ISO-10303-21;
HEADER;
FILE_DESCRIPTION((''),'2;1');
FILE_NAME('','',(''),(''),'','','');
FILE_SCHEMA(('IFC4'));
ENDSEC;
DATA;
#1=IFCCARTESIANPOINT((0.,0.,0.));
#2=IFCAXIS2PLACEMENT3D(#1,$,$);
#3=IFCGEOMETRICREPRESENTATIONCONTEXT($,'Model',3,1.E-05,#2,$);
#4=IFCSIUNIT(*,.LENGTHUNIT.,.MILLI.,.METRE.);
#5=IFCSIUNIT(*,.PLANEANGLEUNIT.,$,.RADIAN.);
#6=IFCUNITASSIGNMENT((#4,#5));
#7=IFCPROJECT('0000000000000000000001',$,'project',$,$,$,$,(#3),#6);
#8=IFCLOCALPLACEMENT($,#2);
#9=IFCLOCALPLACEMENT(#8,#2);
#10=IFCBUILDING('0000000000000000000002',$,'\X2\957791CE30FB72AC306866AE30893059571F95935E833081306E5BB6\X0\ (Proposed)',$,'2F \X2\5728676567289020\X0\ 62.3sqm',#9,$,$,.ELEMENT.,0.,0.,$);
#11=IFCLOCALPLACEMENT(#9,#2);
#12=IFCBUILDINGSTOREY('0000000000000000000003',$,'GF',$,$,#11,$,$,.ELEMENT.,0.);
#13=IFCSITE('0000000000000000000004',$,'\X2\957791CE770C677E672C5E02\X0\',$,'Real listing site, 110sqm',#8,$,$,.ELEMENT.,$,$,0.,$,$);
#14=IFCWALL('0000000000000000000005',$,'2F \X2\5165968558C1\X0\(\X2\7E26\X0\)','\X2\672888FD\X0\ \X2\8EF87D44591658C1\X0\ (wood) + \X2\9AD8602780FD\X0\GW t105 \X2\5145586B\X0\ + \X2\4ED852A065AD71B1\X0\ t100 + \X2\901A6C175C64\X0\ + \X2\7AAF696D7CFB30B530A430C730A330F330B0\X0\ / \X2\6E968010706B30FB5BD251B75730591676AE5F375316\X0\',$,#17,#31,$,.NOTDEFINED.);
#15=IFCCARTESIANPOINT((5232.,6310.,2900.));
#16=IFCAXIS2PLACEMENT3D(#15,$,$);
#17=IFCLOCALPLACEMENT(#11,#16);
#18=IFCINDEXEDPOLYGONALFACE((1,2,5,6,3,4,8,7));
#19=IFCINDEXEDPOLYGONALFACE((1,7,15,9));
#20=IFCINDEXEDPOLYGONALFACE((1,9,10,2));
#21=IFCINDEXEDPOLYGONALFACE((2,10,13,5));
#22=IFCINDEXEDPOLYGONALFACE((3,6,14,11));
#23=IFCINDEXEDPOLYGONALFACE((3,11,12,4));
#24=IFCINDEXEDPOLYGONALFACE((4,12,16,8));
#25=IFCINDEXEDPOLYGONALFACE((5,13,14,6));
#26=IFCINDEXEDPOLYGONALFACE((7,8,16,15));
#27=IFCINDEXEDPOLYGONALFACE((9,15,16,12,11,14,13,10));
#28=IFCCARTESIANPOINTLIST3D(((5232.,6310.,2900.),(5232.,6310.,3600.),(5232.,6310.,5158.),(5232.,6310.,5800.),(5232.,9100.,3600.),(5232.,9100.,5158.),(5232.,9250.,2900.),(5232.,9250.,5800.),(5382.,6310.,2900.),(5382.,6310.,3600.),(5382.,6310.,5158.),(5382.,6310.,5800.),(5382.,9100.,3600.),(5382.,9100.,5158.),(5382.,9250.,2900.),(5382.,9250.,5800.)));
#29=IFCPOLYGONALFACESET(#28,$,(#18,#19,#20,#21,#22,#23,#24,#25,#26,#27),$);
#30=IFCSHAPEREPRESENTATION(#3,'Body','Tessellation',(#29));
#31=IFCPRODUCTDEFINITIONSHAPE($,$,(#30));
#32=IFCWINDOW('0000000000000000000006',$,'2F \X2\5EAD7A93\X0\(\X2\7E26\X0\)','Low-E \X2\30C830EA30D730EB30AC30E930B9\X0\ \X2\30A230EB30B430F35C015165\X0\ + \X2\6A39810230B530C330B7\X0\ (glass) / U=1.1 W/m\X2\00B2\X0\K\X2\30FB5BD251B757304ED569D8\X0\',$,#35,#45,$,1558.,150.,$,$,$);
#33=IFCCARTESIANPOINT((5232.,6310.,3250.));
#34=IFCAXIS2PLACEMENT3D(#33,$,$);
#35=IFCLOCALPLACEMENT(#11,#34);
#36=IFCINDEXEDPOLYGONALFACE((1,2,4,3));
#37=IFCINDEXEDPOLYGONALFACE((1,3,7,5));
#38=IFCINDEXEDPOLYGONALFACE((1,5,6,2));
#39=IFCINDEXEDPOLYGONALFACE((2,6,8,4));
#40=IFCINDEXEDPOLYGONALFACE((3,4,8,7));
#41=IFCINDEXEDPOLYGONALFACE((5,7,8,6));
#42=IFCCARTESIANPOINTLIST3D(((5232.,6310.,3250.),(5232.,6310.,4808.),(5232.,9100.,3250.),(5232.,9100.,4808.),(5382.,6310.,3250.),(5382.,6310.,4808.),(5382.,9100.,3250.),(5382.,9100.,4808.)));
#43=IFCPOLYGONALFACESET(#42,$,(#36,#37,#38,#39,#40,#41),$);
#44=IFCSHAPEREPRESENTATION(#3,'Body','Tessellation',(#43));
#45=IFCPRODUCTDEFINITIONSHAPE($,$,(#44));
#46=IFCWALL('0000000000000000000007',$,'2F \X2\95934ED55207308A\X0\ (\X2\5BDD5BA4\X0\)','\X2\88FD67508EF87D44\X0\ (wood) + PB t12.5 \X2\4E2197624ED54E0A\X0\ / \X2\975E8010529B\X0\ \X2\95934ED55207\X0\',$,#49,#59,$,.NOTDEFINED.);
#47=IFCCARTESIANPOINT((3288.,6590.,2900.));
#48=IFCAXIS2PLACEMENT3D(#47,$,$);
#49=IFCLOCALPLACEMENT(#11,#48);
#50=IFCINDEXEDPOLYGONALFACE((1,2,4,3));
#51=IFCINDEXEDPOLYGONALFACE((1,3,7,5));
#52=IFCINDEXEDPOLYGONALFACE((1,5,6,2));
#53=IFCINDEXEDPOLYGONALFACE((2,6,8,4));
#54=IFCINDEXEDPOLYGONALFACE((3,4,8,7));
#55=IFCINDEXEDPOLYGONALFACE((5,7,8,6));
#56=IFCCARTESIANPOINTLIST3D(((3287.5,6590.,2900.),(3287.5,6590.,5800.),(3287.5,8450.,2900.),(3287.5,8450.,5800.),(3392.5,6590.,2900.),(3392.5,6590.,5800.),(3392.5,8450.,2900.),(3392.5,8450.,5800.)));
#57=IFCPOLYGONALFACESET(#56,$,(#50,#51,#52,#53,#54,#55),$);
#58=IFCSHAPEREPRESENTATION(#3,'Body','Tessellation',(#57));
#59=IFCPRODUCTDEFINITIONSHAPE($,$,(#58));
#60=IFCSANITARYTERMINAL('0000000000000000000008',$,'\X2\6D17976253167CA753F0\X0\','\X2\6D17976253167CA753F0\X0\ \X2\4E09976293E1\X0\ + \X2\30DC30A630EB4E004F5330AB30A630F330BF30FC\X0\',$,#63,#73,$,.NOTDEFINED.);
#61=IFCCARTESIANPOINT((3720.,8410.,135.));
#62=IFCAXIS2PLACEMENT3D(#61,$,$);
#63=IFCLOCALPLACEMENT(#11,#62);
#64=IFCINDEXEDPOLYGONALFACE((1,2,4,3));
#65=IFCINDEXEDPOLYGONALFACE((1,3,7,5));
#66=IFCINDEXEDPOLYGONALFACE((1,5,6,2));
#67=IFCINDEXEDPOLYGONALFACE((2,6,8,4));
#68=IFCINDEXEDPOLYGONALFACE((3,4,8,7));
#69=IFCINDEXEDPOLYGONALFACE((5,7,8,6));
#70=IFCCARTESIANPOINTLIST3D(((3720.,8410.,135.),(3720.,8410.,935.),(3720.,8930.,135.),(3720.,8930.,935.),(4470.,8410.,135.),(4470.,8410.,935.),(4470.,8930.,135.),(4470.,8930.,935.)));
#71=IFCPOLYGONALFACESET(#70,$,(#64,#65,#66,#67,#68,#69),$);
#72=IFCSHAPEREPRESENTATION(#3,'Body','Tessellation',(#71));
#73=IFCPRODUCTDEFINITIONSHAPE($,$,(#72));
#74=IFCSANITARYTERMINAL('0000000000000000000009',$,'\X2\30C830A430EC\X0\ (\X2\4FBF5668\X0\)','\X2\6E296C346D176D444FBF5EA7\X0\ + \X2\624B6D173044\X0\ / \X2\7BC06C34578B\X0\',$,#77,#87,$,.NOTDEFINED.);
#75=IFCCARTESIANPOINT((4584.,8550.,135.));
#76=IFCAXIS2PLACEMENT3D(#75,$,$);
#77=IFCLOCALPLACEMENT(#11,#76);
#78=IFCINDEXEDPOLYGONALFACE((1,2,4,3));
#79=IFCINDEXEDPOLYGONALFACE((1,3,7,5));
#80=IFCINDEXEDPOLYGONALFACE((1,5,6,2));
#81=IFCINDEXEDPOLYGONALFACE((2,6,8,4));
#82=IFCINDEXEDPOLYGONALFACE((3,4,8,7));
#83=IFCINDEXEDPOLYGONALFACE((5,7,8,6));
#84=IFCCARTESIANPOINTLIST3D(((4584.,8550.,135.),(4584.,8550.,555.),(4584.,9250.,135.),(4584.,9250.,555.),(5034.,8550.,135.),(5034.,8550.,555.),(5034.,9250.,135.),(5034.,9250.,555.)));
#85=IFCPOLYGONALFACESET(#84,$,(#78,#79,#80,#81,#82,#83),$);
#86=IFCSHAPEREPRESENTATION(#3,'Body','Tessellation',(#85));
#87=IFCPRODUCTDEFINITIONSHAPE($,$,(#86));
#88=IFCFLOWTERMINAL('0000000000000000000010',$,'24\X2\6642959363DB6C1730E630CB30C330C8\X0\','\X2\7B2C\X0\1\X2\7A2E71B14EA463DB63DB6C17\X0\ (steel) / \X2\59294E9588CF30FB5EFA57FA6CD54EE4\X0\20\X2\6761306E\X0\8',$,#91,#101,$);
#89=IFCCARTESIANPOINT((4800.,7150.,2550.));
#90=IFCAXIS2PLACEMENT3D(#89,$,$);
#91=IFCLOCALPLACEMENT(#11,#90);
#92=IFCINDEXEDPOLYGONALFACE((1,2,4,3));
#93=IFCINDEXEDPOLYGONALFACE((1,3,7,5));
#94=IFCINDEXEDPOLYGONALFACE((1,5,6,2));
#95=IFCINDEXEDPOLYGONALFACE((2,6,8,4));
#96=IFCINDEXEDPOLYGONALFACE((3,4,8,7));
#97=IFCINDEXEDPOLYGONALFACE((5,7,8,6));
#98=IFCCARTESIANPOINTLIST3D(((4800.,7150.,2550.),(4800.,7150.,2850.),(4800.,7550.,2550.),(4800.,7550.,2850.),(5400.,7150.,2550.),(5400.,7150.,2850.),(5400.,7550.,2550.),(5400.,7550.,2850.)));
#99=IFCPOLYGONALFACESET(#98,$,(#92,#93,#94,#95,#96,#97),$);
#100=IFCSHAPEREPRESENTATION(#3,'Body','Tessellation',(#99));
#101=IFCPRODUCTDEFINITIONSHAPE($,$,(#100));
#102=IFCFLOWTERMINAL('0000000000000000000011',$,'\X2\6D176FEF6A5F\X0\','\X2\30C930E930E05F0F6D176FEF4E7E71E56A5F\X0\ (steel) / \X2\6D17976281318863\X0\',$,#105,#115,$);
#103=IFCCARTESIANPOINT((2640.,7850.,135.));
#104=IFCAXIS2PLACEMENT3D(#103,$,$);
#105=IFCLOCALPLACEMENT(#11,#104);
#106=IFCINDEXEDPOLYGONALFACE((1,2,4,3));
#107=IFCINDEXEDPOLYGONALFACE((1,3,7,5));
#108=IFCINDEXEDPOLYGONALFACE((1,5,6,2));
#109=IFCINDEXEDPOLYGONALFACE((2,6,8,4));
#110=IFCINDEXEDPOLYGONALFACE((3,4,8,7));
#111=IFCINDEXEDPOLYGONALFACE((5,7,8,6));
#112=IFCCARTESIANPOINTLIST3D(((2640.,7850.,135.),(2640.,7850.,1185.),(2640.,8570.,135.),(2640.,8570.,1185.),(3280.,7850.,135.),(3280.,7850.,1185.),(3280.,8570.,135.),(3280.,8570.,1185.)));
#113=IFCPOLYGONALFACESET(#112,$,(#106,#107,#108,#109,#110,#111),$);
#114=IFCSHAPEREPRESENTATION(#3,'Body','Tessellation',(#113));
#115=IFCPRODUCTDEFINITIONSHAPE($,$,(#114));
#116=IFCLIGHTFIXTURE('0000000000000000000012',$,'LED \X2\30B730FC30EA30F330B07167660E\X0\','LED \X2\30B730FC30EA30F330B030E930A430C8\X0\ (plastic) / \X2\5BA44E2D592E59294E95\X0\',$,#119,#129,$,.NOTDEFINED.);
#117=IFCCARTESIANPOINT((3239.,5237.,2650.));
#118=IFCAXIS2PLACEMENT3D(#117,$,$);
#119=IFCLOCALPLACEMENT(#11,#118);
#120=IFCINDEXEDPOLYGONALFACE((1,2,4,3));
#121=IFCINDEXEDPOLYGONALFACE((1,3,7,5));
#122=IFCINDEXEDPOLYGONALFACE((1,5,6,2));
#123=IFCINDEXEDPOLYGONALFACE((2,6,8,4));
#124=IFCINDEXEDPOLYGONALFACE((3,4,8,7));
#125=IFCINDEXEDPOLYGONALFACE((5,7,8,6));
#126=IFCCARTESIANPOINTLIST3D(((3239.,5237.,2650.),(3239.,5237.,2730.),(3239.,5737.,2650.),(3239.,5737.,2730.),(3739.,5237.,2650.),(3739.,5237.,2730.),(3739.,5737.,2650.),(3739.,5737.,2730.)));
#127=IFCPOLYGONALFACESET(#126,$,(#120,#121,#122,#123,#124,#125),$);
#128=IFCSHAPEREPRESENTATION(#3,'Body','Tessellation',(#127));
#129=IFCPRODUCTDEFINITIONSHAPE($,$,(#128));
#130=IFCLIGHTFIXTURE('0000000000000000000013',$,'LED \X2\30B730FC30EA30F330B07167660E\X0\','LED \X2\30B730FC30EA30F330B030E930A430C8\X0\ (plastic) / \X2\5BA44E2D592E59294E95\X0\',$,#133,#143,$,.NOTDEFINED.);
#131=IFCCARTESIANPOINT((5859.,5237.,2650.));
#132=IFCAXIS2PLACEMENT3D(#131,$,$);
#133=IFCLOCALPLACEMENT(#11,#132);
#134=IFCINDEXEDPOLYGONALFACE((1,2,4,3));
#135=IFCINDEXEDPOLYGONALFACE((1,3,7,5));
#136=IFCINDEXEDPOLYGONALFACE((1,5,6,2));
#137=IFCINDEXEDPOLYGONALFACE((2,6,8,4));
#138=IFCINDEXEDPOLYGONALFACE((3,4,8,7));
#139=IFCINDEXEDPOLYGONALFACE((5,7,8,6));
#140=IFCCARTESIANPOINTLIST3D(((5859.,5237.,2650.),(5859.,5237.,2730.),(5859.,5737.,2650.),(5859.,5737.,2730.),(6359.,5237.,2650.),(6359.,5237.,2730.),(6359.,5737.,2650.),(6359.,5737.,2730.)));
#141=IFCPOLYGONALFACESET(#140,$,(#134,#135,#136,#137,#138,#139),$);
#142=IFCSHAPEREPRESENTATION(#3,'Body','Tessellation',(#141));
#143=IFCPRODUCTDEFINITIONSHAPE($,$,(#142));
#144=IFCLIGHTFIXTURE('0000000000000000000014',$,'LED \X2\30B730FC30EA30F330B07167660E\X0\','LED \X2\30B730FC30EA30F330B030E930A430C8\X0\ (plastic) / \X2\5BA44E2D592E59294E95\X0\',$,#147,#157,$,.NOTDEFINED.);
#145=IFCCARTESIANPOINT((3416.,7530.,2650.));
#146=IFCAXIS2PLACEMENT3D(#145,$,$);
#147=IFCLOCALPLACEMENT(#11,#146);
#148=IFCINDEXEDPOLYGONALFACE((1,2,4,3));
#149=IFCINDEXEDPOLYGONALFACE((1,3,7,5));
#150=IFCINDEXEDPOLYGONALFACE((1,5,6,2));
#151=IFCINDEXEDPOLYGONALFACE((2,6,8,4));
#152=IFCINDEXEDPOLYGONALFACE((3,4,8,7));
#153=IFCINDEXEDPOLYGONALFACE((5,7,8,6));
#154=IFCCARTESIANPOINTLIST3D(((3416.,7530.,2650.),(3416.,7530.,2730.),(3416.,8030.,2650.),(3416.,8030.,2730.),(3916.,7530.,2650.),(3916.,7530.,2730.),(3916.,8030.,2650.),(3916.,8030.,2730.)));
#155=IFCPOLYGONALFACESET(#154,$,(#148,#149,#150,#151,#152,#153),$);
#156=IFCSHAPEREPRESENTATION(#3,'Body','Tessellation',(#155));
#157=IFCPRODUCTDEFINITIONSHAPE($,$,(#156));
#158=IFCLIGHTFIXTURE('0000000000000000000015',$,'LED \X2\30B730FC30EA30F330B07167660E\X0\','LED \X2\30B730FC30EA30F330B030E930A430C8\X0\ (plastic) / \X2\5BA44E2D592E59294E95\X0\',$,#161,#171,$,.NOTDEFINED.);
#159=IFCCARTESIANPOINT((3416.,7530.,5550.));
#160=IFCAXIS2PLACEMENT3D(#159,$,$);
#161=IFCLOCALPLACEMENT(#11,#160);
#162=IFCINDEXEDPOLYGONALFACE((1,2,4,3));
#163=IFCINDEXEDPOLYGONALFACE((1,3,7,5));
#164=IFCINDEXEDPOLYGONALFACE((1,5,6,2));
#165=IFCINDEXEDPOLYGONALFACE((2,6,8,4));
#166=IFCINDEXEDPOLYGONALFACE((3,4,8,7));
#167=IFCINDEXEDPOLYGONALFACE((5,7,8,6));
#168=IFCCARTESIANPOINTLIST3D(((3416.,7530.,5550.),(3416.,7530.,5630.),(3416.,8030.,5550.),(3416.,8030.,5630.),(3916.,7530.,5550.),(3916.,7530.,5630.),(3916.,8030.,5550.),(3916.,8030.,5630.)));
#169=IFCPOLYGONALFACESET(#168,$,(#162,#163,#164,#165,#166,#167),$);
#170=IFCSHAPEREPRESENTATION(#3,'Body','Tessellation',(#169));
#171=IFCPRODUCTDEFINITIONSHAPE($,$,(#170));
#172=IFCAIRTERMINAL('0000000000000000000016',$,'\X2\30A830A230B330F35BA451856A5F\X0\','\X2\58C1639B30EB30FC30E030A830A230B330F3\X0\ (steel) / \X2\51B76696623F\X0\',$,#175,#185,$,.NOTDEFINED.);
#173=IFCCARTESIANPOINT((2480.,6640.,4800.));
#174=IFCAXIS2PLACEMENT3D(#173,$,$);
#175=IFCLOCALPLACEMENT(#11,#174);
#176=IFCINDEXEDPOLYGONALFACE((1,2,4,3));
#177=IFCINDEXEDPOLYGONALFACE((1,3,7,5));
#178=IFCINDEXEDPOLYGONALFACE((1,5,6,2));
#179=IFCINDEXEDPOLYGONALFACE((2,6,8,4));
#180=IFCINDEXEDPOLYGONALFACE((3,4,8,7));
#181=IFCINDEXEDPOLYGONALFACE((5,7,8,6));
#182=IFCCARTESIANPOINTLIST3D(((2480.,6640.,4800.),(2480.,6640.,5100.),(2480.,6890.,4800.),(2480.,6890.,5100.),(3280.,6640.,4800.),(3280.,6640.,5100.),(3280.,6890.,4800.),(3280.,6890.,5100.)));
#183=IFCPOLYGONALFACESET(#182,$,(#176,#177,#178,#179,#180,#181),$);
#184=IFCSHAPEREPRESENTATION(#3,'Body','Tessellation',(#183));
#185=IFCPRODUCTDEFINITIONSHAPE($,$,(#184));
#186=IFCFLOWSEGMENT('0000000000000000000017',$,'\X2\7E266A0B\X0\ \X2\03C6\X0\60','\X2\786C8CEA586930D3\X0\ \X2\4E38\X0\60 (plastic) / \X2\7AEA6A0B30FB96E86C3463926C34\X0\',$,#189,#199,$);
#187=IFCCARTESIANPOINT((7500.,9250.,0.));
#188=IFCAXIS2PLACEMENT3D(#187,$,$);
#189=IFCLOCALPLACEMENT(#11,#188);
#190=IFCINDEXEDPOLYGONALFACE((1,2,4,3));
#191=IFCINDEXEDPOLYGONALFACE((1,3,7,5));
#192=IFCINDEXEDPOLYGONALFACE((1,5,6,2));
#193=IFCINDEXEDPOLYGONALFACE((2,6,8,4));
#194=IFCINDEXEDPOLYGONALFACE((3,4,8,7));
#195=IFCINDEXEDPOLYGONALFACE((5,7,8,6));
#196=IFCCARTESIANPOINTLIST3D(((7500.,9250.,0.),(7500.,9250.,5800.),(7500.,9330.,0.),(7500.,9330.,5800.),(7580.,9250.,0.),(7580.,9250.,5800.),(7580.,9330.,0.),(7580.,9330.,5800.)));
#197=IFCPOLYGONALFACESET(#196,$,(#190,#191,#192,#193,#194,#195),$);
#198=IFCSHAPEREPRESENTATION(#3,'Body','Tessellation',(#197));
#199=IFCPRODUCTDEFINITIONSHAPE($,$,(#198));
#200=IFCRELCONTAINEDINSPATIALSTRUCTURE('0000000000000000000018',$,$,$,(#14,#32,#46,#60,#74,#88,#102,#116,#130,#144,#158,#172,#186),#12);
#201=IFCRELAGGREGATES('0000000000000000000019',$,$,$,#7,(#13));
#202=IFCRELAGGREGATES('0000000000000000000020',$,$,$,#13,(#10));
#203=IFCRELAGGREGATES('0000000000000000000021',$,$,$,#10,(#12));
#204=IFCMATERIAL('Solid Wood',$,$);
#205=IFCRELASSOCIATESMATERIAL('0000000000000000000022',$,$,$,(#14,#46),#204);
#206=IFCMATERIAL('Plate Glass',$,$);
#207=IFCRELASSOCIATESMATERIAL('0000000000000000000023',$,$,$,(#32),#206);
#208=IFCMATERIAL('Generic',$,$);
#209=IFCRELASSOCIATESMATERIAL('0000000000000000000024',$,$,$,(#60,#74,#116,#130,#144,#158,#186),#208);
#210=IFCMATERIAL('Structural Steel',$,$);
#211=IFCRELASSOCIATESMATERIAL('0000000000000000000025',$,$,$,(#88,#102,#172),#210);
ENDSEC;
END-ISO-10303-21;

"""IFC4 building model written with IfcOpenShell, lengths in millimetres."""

from ifc_helpers import new_model, si_unit, frame, frame_2d, origin, place, context, project, spatial, rectangle, extrude, material, element, fill, save


model = new_model("IFC4")

# Units and contexts
model_context = context("Model", 3, precision=1e-05, world=origin())
ifc_project = project(units=[si_unit("LENGTHUNIT", "METRE", prefix="MILLI"), si_unit("PLANEANGLEUNIT", "RADIAN")], contexts=[model_context])

# Site, building, storey
site_placement = place(None, origin())
site = spatial("IfcSite", under=ifc_project, at=site_placement, Name="長野県松本市", ObjectType="Real listing site, 110sqm", CompositionType="ELEMENT", RefElevation=0.0)
building_placement = place(site_placement, origin())
building = spatial("IfcBuilding", under=site, at=building_placement, Name="長野・犬と暮らす土間広めの家 (Proposed)", ObjectType="2F 在来木造 62.3sqm", CompositionType="ELEMENT", ElevationOfRefHeight=0.0, ElevationOfTerrain=0.0)
storey_placement = place(building_placement, origin())
storey = spatial("IfcBuildingStorey", under=building, at=storey_placement, Name="GF", CompositionType="ELEMENT", Elevation=0.0)

# Shared definitions
ifc_material_1 = material(Name="Solid Wood")

# Shared definitions
ifc_material_2 = material(Name="Plate Glass")

# Wall, opening, window
wall_1_placement = place(storey_placement, frame((5232.0, 6310.0, 2900.0)))
wall_1 = element("IfcWall", 1, at=wall_1_placement, inside=storey, material=ifc_material_1, Name="2F 入隅壁(縦)", Description="木製 軸組外壁 (wood) + 高性能GW t105 充填 + 付加断熱 t100 + 通気層 + 窯業系サイディング / 準耐火・寒冷地外皮強化", PredefinedType="NOTDEFINED", context=model_context, shape_type="SweptSolid", body=[
    extrude(rectangle(XDim=150.0, YDim=2940.0, at=frame_2d((75.0, 1470.0))), frame((5232.0, 6310.0, 2900.0)), (0.0, 0.0, 1.0), 2900.0),
])
opening_1_placement = place(storey_placement, frame((5232.0, 6310.0, 3250.0)))
opening_1 = element("IfcOpeningElement", 2, at=opening_1_placement, cuts=wall_1, PredefinedType="NOTDEFINED", context=model_context, shape_type="SweptSolid", body=[
    extrude(rectangle(XDim=150.0, YDim=2790.0, at=frame_2d((75.0, 1395.0))), frame((5232.0, 6310.0, 3250.0)), (0.0, 0.0, 1.0), 1558.0),
])
window_1_placement = place(storey_placement, frame((5232.0, 6310.0, 3250.0)))
window_1 = element("IfcWindow", 3, at=window_1_placement, inside=storey, material=ifc_material_2, Name="2F 庭窓(縦)", Description="Low-E トリプルガラス アルゴン封入 + 樹脂サッシ (glass) / U=1.1 W/m²K・寒冷地仕様", OverallHeight=1558.0, OverallWidth=150.0, context=model_context, shape_type="SweptSolid", body=[
    extrude(rectangle(XDim=150.0, YDim=2790.0, at=frame_2d((75.0, 1395.0))), frame((5232.0, 6310.0, 3250.0)), (0.0, 0.0, 1.0), 1558.0),
])
fill(opening_1, window_1)

# Wall
wall_2_placement = place(storey_placement, frame((3288.0, 6590.0, 2900.0)))
element("IfcWall", 4, at=wall_2_placement, inside=storey, material=ifc_material_1, Name="2F 間仕切り (寝室)", Description="製材軸組 (wood) + PB t12.5 両面仕上 / 非耐力 間仕切", PredefinedType="NOTDEFINED", context=model_context, shape_type="SweptSolid", body=[
    extrude(rectangle(XDim=105.0, YDim=1860.0, at=frame_2d((52.0, 930.0))), frame((3288.0, 6590.0, 2900.0)), (0.0, 0.0, 1.0), 2900.0),
])

# Sanitary terminals
ifc_material_3 = material(Name="Generic")
sanitary_terminal_1_placement = place(storey_placement, frame((3720.0, 8410.0, 135.0)))
element("IfcSanitaryTerminal", 5, at=sanitary_terminal_1_placement, inside=storey, material=ifc_material_3, Name="洗面化粧台", Description="洗面化粧台 三面鏡 + ボウル一体カウンター", PredefinedType="NOTDEFINED", context=model_context, shape_type="SweptSolid", body=[
    extrude(rectangle(XDim=750.0, YDim=520.0, at=frame_2d((375.0, 260.0))), frame((3720.0, 8410.0, 135.0)), (0.0, 0.0, 1.0), 800.0),
])
sanitary_terminal_2_placement = place(storey_placement, frame((4584.0, 8550.0, 135.0)))
element("IfcSanitaryTerminal", 6, at=sanitary_terminal_2_placement, inside=storey, material=ifc_material_3, Name="トイレ (便器)", Description="温水洗浄便座 + 手洗い / 節水型", PredefinedType="NOTDEFINED", context=model_context, shape_type="SweptSolid", body=[
    extrude(rectangle(XDim=450.0, YDim=700.0, at=frame_2d((225.0, 350.0))), frame((4584.0, 8550.0, 135.0)), (0.0, 0.0, 1.0), 420.0),
])

# Flow terminals
ifc_material_4 = material(Name="Structural Steel")
flow_terminal_1_placement = place(storey_placement, frame((4800.0, 7150.0, 2550.0)))
element("IfcFlowTerminal", 7, at=flow_terminal_1_placement, inside=storey, material=ifc_material_4, Name="24時間換気ユニット", Description="第1種熱交換換気 (steel) / 天井裏・建基法令20条の8", context=model_context, shape_type="SweptSolid", body=[
    extrude(rectangle(XDim=600.0, YDim=400.0, at=frame_2d((300.0, 200.0))), frame((4800.0, 7150.0, 2550.0)), (0.0, 0.0, 1.0), 300.0),
])
flow_terminal_2_placement = place(storey_placement, frame((2640.0, 7850.0, 135.0)))
element("IfcFlowTerminal", 8, at=flow_terminal_2_placement, inside=storey, material=ifc_material_4, Name="洗濯機", Description="ドラム式洗濯乾燥機 (steel) / 洗面脱衣", context=model_context, shape_type="SweptSolid", body=[
    extrude(rectangle(XDim=640.0, YDim=720.0, at=frame_2d((320.0, 360.0))), frame((2640.0, 7850.0, 135.0)), (0.0, 0.0, 1.0), 1050.0),
])

# Light fixtures
light_fixture_1_placement = place(storey_placement, frame((3239.0, 5237.0, 2650.0)))
element("IfcLightFixture", 9, at=light_fixture_1_placement, inside=storey, material=ifc_material_3, Name="LED シーリング照明", Description="LED シーリングライト (plastic) / 室中央天井", PredefinedType="NOTDEFINED", context=model_context, shape_type="SweptSolid", body=[
    extrude(rectangle(XDim=500.0, YDim=500.0, at=frame_2d((250.0, 250.0))), frame((3239.0, 5237.0, 2650.0)), (0.0, 0.0, 1.0), 80.0),
])
light_fixture_2_placement = place(storey_placement, frame((5859.0, 5237.0, 2650.0)))
element("IfcLightFixture", 10, at=light_fixture_2_placement, inside=storey, material=ifc_material_3, Name="LED シーリング照明", Description="LED シーリングライト (plastic) / 室中央天井", PredefinedType="NOTDEFINED", context=model_context, shape_type="SweptSolid", body=[
    extrude(rectangle(XDim=500.0, YDim=500.0, at=frame_2d((250.0, 250.0))), frame((5859.0, 5237.0, 2650.0)), (0.0, 0.0, 1.0), 80.0),
])
light_fixture_3_placement = place(storey_placement, frame((3416.0, 7530.0, 2650.0)))
element("IfcLightFixture", 11, at=light_fixture_3_placement, inside=storey, material=ifc_material_3, Name="LED シーリング照明", Description="LED シーリングライト (plastic) / 室中央天井", PredefinedType="NOTDEFINED", context=model_context, shape_type="SweptSolid", body=[
    extrude(rectangle(XDim=500.0, YDim=500.0, at=frame_2d((250.0, 250.0))), frame((3416.0, 7530.0, 2650.0)), (0.0, 0.0, 1.0), 80.0),
])
light_fixture_4_placement = place(storey_placement, frame((3416.0, 7530.0, 5550.0)))
element("IfcLightFixture", 12, at=light_fixture_4_placement, inside=storey, material=ifc_material_3, Name="LED シーリング照明", Description="LED シーリングライト (plastic) / 室中央天井", PredefinedType="NOTDEFINED", context=model_context, shape_type="SweptSolid", body=[
    extrude(rectangle(XDim=500.0, YDim=500.0, at=frame_2d((250.0, 250.0))), frame((3416.0, 7530.0, 5550.0)), (0.0, 0.0, 1.0), 80.0),
])

# Air terminal
air_terminal_placement = place(storey_placement, frame((2480.0, 6640.0, 4800.0)))
element("IfcAirTerminal", 13, at=air_terminal_placement, inside=storey, material=ifc_material_4, Name="エアコン室内機", Description="壁掛ルームエアコン (steel) / 冷暖房", PredefinedType="NOTDEFINED", context=model_context, shape_type="SweptSolid", body=[
    extrude(rectangle(XDim=800.0, YDim=250.0, at=frame_2d((400.0, 125.0))), frame((2480.0, 6640.0, 4800.0)), (0.0, 0.0, 1.0), 300.0),
])

# Flow segment
flow_segment_placement = place(storey_placement, frame((7500.0, 9250.0, 0.0)))
element("IfcFlowSegment", 14, at=flow_segment_placement, inside=storey, material=ifc_material_3, Name="縦樋 φ60", Description="硬質塩ビ 丸60 (plastic) / 竪樋・雨水排水", context=model_context, shape_type="SweptSolid", body=[
    extrude(rectangle(XDim=80.0, YDim=80.0, at=frame_2d((40.0, 40.0))), frame((7500.0, 9250.0, 0.0)), (0.0, 0.0, 1.0), 5800.0),
])

save(model, "model.ifc")
